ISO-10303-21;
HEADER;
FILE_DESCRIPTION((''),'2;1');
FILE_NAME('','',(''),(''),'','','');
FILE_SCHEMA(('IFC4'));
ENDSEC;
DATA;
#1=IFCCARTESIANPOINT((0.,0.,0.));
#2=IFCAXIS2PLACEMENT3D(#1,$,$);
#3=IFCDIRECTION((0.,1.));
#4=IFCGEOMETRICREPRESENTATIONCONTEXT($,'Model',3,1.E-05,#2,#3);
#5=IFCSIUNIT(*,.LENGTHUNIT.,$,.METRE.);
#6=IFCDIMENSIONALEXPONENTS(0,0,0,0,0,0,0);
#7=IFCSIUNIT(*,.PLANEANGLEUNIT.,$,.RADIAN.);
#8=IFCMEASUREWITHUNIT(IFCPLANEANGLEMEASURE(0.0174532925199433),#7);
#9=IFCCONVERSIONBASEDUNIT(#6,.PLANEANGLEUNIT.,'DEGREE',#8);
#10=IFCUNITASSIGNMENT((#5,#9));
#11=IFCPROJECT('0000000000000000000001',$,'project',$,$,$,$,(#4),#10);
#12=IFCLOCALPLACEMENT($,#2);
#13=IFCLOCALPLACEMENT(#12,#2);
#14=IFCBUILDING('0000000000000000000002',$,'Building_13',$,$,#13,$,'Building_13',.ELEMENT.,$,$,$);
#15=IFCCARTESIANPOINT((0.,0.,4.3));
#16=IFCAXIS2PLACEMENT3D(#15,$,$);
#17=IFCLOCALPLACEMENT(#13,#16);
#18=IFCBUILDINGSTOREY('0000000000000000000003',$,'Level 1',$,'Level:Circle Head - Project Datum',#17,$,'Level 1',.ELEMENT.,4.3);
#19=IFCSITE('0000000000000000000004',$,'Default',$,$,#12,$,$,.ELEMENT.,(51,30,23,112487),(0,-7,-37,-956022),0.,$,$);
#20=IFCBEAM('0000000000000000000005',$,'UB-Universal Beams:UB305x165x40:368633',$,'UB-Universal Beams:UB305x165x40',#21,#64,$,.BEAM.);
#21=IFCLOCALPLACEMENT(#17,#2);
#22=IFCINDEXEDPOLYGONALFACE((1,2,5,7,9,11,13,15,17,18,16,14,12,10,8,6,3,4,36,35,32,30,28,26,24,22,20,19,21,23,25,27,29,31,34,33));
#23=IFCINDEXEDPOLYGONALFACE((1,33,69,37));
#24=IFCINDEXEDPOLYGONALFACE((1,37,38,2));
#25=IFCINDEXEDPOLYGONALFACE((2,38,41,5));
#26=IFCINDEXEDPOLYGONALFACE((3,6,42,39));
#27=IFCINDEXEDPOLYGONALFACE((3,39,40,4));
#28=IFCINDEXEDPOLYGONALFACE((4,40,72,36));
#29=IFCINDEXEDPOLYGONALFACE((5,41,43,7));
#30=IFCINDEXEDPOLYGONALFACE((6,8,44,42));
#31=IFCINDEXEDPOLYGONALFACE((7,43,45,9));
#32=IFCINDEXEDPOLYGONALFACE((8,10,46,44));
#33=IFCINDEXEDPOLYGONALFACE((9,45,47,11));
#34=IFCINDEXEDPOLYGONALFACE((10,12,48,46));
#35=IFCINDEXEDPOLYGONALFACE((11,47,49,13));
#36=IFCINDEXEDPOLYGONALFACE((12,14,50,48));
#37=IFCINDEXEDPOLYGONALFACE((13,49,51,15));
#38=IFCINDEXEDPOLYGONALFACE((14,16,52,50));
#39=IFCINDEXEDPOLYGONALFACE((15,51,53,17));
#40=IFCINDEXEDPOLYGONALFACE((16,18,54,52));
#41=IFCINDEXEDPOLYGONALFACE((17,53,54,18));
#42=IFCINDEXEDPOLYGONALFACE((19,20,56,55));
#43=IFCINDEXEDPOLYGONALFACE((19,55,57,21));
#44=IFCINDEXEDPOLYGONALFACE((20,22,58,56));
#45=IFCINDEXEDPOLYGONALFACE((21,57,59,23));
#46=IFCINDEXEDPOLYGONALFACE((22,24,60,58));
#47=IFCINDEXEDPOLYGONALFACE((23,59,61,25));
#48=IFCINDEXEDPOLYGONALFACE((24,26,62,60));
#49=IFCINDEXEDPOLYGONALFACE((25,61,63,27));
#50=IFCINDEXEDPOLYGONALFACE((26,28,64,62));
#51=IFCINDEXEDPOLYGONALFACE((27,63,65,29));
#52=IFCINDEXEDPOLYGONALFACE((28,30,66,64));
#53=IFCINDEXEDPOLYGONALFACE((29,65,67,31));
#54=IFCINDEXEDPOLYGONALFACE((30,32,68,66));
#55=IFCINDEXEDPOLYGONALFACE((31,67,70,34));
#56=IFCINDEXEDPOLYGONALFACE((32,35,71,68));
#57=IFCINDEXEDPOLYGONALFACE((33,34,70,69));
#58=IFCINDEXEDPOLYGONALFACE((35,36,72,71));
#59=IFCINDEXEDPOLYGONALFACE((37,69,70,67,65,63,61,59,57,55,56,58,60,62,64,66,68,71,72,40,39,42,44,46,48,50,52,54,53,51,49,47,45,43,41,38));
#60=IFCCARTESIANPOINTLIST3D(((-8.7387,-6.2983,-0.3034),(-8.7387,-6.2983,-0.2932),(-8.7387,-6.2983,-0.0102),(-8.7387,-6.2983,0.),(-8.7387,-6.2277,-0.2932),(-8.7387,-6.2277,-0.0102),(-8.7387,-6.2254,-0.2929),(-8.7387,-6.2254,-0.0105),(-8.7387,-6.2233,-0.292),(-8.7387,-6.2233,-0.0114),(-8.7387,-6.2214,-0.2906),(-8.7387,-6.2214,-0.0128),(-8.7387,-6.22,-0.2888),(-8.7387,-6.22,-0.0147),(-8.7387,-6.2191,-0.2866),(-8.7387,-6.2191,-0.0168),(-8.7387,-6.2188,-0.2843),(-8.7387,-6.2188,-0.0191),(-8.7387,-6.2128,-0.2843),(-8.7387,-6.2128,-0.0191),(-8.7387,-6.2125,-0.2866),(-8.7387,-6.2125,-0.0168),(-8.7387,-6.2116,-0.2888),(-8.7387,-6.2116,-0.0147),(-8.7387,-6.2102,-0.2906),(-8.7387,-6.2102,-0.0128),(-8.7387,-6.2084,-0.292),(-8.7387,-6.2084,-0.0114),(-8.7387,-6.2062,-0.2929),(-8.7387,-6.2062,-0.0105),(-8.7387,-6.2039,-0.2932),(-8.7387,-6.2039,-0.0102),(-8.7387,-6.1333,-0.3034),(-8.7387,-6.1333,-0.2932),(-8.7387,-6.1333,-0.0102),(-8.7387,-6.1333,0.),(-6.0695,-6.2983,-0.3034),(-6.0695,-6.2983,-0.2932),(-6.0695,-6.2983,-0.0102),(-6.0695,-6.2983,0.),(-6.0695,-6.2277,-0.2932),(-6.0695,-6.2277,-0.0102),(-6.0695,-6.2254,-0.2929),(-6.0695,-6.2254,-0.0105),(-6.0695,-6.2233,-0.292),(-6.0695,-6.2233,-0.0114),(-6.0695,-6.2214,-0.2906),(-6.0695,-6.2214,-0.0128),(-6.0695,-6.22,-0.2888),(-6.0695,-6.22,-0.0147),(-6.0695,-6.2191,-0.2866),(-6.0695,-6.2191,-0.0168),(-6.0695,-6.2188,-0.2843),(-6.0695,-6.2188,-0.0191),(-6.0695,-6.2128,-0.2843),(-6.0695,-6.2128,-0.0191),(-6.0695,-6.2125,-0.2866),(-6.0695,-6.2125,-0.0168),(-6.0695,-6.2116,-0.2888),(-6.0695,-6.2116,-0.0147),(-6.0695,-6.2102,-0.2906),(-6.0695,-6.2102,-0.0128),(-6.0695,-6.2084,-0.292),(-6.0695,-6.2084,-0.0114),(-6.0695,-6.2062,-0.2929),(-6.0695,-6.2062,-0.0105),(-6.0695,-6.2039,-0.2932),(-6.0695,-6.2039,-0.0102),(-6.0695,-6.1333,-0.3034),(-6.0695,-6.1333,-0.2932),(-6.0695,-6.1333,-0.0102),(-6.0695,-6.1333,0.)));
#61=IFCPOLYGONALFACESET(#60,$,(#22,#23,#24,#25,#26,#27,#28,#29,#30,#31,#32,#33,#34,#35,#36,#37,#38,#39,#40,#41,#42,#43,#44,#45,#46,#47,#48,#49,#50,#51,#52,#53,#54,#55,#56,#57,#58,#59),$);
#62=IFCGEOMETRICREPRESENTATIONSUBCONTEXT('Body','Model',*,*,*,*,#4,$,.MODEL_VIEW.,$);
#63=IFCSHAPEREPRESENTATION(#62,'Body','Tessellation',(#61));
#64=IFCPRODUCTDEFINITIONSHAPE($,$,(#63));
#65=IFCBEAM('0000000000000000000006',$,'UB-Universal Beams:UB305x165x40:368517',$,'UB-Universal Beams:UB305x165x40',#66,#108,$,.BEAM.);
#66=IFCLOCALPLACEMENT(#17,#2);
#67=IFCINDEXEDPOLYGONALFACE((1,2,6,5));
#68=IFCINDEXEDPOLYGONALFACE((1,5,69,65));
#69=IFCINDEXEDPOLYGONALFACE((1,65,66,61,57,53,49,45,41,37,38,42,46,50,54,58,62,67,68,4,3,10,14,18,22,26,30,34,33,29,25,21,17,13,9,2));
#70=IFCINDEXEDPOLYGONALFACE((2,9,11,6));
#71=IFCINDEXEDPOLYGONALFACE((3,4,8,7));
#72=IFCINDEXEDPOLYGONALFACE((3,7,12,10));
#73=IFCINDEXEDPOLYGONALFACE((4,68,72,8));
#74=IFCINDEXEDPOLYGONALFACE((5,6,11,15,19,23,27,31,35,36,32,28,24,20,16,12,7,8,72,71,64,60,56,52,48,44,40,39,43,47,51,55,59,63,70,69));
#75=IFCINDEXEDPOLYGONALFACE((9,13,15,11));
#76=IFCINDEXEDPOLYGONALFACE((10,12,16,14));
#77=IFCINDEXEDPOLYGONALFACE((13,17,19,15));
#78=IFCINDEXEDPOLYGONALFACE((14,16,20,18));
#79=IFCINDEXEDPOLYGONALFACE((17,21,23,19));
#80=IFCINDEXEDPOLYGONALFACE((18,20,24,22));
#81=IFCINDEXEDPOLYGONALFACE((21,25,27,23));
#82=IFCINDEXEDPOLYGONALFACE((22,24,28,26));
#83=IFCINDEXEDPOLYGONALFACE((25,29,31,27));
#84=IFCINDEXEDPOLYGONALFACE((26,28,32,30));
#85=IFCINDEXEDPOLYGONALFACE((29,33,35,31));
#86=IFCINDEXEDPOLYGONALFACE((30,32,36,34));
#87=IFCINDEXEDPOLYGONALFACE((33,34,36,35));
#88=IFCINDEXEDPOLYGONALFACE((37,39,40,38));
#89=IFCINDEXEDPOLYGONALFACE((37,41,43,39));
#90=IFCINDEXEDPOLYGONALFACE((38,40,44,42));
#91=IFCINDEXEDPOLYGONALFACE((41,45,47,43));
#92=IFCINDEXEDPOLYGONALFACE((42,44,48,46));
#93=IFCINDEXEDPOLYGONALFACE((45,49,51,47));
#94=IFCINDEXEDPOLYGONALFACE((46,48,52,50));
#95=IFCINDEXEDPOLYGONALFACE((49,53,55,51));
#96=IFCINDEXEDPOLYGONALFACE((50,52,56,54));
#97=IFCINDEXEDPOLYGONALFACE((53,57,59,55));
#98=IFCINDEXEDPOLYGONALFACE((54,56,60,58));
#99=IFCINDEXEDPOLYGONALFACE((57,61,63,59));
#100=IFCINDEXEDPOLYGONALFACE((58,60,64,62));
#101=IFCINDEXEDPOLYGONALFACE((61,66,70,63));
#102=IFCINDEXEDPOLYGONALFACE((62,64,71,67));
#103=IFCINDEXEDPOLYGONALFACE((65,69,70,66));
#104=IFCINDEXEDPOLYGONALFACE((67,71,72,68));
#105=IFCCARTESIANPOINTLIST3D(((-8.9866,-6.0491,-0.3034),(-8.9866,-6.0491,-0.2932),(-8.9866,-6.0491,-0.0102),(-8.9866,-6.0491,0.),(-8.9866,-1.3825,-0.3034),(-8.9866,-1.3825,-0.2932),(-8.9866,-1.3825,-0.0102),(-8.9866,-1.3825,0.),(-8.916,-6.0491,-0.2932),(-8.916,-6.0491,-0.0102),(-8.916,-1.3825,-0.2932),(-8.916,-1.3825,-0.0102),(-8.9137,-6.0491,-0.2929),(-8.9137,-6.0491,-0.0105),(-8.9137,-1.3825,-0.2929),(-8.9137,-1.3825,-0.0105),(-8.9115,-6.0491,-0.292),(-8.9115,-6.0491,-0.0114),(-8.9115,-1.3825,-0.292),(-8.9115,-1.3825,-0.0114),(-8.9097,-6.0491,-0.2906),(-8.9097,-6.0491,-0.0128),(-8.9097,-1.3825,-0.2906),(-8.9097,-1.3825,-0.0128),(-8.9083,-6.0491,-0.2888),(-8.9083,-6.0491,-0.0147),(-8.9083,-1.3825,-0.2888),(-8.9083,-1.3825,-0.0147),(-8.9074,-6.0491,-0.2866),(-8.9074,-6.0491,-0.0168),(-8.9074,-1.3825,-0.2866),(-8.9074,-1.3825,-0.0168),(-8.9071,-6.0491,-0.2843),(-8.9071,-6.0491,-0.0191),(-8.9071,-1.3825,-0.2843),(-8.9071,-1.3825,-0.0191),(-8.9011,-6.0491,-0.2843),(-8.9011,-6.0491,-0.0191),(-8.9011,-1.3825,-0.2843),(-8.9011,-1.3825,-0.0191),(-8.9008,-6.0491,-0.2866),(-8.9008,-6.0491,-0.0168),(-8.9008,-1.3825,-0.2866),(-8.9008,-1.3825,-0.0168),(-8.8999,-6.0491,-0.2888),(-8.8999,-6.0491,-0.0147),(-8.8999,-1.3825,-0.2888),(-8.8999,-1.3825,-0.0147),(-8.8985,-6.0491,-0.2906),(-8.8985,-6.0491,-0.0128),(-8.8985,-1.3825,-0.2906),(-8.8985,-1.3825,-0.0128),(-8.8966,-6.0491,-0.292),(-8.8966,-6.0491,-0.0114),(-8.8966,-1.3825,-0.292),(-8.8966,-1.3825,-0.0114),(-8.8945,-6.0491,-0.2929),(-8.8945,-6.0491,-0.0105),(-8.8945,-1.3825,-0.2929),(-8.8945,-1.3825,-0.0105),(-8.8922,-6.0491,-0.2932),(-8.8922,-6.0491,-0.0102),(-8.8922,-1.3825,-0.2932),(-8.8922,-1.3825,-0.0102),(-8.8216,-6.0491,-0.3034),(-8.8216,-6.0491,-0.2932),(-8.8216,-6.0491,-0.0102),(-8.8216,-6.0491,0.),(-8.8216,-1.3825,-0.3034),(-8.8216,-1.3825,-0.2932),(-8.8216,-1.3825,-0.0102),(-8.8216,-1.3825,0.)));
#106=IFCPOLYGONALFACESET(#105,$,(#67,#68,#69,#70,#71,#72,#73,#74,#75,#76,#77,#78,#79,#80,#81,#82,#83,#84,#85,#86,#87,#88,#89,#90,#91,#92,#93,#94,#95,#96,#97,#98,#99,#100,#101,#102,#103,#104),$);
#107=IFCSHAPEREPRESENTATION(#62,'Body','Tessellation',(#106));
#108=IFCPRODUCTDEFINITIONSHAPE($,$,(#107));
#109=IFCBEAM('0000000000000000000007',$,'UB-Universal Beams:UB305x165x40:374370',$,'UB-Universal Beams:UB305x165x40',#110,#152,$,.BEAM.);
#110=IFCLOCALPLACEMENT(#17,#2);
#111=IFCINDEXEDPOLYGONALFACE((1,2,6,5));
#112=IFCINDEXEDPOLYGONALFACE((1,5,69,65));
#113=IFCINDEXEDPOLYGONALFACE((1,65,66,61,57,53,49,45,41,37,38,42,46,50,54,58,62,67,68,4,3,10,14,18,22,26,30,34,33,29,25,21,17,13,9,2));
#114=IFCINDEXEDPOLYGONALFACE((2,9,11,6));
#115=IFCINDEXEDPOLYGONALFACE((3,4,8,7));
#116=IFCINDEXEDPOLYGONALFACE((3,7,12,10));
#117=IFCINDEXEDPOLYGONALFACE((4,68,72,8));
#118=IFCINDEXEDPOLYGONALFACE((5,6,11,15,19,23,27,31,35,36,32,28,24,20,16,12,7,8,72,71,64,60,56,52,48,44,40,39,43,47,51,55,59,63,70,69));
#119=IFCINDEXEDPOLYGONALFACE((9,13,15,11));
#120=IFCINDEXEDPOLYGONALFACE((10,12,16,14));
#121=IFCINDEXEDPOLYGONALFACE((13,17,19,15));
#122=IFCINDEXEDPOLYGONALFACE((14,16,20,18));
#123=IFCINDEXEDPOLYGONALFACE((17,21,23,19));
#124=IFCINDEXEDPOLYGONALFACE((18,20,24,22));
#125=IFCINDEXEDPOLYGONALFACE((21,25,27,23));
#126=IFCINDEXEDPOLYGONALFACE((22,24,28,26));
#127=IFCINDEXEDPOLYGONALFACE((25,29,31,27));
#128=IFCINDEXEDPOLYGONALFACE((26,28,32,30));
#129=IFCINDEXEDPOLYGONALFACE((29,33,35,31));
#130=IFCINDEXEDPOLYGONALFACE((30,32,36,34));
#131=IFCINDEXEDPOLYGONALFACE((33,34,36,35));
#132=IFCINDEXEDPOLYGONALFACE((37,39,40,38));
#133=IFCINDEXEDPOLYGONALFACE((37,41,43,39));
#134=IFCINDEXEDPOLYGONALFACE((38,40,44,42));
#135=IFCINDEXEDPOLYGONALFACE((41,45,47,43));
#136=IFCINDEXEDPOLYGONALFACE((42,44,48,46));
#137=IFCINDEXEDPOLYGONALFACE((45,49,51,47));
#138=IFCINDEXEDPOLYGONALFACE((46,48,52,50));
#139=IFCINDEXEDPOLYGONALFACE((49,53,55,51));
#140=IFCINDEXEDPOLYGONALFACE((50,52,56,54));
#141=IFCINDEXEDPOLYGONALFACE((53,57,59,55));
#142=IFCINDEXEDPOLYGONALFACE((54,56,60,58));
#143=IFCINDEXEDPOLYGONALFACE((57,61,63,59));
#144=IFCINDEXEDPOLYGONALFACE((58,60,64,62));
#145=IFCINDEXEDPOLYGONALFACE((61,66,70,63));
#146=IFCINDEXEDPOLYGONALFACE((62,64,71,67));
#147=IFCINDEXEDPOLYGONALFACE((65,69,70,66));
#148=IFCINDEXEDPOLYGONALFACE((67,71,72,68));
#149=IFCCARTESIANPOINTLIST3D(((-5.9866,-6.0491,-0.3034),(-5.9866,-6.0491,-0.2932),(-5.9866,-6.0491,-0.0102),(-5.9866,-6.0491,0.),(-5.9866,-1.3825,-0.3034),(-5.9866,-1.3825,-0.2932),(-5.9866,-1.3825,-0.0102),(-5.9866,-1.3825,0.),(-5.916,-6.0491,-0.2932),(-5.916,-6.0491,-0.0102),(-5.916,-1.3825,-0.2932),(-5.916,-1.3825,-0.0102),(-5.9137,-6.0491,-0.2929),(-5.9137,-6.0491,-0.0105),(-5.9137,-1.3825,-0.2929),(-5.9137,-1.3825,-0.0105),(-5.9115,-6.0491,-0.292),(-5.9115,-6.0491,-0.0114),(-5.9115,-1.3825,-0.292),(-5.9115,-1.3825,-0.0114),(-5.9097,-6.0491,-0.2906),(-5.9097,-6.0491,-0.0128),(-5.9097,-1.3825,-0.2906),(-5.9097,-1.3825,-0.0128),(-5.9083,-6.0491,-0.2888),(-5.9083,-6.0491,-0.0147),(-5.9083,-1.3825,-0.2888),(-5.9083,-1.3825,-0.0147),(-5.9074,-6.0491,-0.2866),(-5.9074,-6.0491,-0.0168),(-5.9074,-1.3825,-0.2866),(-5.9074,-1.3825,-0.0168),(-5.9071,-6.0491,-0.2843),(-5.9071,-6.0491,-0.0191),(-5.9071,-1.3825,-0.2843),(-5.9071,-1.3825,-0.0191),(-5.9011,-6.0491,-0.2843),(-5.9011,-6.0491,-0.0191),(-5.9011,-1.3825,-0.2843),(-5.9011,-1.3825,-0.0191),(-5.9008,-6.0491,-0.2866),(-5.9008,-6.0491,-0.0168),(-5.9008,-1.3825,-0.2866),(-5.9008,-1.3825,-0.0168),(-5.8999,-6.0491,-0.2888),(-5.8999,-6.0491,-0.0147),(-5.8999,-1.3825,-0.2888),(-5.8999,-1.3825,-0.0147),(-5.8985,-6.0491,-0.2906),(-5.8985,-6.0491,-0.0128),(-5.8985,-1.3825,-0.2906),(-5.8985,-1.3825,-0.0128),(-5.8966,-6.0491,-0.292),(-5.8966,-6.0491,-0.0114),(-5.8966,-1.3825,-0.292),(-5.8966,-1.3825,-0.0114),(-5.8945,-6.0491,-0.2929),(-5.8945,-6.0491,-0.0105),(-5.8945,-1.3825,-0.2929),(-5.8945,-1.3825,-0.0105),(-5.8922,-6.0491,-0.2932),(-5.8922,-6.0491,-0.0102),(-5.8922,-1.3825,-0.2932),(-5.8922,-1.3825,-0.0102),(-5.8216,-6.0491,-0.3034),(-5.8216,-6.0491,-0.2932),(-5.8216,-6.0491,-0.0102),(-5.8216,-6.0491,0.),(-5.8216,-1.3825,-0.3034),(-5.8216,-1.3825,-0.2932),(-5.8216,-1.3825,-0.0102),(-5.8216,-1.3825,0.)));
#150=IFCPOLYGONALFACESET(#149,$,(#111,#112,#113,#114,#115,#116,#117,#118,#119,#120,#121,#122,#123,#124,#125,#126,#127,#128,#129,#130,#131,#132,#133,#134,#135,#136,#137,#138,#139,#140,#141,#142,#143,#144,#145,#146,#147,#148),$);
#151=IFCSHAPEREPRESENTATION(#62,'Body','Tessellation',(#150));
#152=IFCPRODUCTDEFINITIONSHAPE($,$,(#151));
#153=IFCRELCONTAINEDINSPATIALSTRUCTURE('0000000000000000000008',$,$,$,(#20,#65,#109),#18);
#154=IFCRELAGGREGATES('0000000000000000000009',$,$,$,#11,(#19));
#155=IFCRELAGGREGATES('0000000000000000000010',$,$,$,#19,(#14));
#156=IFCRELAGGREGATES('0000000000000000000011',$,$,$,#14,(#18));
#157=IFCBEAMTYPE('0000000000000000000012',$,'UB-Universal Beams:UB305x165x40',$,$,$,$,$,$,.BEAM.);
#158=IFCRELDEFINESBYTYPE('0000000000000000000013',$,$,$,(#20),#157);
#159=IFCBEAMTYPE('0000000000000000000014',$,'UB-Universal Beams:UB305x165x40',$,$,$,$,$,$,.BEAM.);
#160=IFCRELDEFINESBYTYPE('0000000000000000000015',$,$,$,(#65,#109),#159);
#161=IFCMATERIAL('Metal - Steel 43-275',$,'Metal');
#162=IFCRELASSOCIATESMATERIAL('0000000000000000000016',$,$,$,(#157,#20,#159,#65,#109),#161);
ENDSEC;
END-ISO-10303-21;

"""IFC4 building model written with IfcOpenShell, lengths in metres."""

from ifc_helpers import new_model, entity, si_unit, converted_unit, direction, frame, origin, place, context, subcontext, project, spatial, line, arc, indexed_curve, outline, extrude, source, transform, mapped, material, type_object, type_shapes, element, save


model = new_model("IFC4")

# Units and contexts
model_context = context("Model", 3, precision=1e-05, world=origin(), true_north=direction((0.0, 1.0)))
body_context = subcontext(model_context, "Body", "Model", "MODEL_VIEW")
ifc_project = project(units=[si_unit("LENGTHUNIT", "METRE"), converted_unit("PLANEANGLEUNIT", "DEGREE", entity("IfcPlaneAngleMeasure", 0.0174532925199433), si_unit("PLANEANGLEUNIT", "RADIAN"), dimensions=[0, 0, 0, 0, 0, 0, 0])], contexts=[model_context])

# Site, building, storey
site_placement = place(None, origin())
site = spatial("IfcSite", under=ifc_project, at=site_placement, Name="Default", CompositionType="ELEMENT", RefLatitude=(51, 30, 23, 112487), RefLongitude=(0, -7, -37, -956022), RefElevation=0.0)
building_placement = place(site_placement, origin())
building = spatial("IfcBuilding", under=site, at=building_placement, Name="Building_13", LongName="Building_13", CompositionType="ELEMENT")
storey_placement = place(building_placement, frame((0.0, 0.0, 4.3)))
storey = spatial("IfcBuildingStorey", under=building, at=storey_placement, Name="Level 1", ObjectType="Level:Circle Head - Project Datum", LongName="Level 1", CompositionType="ELEMENT", Elevation=4.3)

# Beams
ifc_material_1 = material(Name="Metal - Steel 43-275", Category="Metal")
beam_type_1 = type_object("IfcBeamType", Name="UB-Universal Beams:UB305x165x40", PredefinedType="BEAM", material=ifc_material_1)
shared_shape_1 = source(origin(), body_context, "Body", "SweptSolid", [
    extrude(outline(indexed_curve([(-0.0825, -0.1415), (-0.0825, -0.1517), (0.0825, -0.1517), (0.0825, -0.1415), (0.0119, -0.1415), (0.0056, -0.1389), (0.003, -0.1326), (0.003, 0.1326), (0.0056, 0.1389), (0.0119, 0.1415), (0.0825, 0.1415), (0.0825, 0.1517), (-0.0825, 0.1517), (-0.0825, 0.1415), (-0.0119, 0.1415), (-0.0056, 0.1389), (-0.003, 0.1326), (-0.003, -0.1326), (-0.0056, -0.1389), (-0.0119, -0.1415)], segments=[line(1, 2, 3, 4, 5), arc(5, 6, 7), line(7, 8), arc(8, 9, 10), line(10, 11, 12, 13, 14, 15), arc(15, 16, 17), line(17, 18), arc(18, 19, 20), line(20, 1)], self_intersect=False)), frame((-1.3346, 0.0, 0.0), z_axis=(-1.0, 0.0, 0.0), x_axis=(0.0, -1.0, 0.0)), (0.0, 0.0, -1.0), 2.6692),
])
type_shapes(beam_type_1, [shared_shape_1])
beam_placement = place(storey_placement, frame((-7.4041, -6.2158, -0.1517)))
element("IfcBeam", 1, at=beam_placement, inside=storey, type_object=beam_type_1, material=ifc_material_1, Name="UB-Universal Beams:UB305x165x40:368633", ObjectType="UB-Universal Beams:UB305x165x40", PredefinedType="BEAM", context=body_context, shape_type="MappedRepresentation", body=[
    mapped(shared_shape_1, transform((0.0, 0.0, 0.0), scale=1.0)),
])
beam_type_2 = type_object("IfcBeamType", Name="UB-Universal Beams:UB305x165x40", PredefinedType="BEAM", material=ifc_material_1)
shared_shape_2 = source(origin(), body_context, "Body", "SweptSolid", [
    extrude(outline(indexed_curve([(-0.0825, -0.1415), (-0.0825, -0.1517), (0.0825, -0.1517), (0.0825, -0.1415), (0.0119, -0.1415), (0.0056, -0.1389), (0.003, -0.1326), (0.003, 0.1326), (0.0056, 0.1389), (0.0119, 0.1415), (0.0825, 0.1415), (0.0825, 0.1517), (-0.0825, 0.1517), (-0.0825, 0.1415), (-0.0119, 0.1415), (-0.0056, 0.1389), (-0.003, 0.1326), (-0.003, -0.1326), (-0.0056, -0.1389), (-0.0119, -0.1415)], segments=[line(1, 2, 3, 4, 5), arc(5, 6, 7), line(7, 8), arc(8, 9, 10), line(10, 11, 12, 13, 14, 15), arc(15, 16, 17), line(17, 18), arc(18, 19, 20), line(20, 1)], self_intersect=False)), frame((-2.3333, 0.0, 0.0), z_axis=(-1.0, 0.0, 0.0), x_axis=(0.0, -1.0, 0.0)), (0.0, 0.0, -1.0), 4.6666),
])
type_shapes(beam_type_2, [shared_shape_2])
for number, where, z_axis, x_axis, name in (
    (2, (-8.9041, -3.7158, -0.1517), (0.0, 0.0, 1.0), (0.0, -1.0, 0.0), "UB-Universal Beams:UB305x165x40:368517"),
    (3, (-5.9041, -3.7158, -0.1517), (0.0, 0.0, 1.0), (0.0, -1.0, 0.0), "UB-Universal Beams:UB305x165x40:374370"),
):
    element("IfcBeam", number, at=place(storey_placement, frame(where, z_axis=z_axis, x_axis=x_axis)), inside=storey, type_object=beam_type_2, material=ifc_material_1, Name=name, ObjectType="UB-Universal Beams:UB305x165x40", PredefinedType="BEAM", context=body_context, shape_type="MappedRepresentation", body=[
        mapped(shared_shape_2, transform((0.0, 0.0, 0.0), scale=1.0)),
    ])

save(model, "model.ifc")
